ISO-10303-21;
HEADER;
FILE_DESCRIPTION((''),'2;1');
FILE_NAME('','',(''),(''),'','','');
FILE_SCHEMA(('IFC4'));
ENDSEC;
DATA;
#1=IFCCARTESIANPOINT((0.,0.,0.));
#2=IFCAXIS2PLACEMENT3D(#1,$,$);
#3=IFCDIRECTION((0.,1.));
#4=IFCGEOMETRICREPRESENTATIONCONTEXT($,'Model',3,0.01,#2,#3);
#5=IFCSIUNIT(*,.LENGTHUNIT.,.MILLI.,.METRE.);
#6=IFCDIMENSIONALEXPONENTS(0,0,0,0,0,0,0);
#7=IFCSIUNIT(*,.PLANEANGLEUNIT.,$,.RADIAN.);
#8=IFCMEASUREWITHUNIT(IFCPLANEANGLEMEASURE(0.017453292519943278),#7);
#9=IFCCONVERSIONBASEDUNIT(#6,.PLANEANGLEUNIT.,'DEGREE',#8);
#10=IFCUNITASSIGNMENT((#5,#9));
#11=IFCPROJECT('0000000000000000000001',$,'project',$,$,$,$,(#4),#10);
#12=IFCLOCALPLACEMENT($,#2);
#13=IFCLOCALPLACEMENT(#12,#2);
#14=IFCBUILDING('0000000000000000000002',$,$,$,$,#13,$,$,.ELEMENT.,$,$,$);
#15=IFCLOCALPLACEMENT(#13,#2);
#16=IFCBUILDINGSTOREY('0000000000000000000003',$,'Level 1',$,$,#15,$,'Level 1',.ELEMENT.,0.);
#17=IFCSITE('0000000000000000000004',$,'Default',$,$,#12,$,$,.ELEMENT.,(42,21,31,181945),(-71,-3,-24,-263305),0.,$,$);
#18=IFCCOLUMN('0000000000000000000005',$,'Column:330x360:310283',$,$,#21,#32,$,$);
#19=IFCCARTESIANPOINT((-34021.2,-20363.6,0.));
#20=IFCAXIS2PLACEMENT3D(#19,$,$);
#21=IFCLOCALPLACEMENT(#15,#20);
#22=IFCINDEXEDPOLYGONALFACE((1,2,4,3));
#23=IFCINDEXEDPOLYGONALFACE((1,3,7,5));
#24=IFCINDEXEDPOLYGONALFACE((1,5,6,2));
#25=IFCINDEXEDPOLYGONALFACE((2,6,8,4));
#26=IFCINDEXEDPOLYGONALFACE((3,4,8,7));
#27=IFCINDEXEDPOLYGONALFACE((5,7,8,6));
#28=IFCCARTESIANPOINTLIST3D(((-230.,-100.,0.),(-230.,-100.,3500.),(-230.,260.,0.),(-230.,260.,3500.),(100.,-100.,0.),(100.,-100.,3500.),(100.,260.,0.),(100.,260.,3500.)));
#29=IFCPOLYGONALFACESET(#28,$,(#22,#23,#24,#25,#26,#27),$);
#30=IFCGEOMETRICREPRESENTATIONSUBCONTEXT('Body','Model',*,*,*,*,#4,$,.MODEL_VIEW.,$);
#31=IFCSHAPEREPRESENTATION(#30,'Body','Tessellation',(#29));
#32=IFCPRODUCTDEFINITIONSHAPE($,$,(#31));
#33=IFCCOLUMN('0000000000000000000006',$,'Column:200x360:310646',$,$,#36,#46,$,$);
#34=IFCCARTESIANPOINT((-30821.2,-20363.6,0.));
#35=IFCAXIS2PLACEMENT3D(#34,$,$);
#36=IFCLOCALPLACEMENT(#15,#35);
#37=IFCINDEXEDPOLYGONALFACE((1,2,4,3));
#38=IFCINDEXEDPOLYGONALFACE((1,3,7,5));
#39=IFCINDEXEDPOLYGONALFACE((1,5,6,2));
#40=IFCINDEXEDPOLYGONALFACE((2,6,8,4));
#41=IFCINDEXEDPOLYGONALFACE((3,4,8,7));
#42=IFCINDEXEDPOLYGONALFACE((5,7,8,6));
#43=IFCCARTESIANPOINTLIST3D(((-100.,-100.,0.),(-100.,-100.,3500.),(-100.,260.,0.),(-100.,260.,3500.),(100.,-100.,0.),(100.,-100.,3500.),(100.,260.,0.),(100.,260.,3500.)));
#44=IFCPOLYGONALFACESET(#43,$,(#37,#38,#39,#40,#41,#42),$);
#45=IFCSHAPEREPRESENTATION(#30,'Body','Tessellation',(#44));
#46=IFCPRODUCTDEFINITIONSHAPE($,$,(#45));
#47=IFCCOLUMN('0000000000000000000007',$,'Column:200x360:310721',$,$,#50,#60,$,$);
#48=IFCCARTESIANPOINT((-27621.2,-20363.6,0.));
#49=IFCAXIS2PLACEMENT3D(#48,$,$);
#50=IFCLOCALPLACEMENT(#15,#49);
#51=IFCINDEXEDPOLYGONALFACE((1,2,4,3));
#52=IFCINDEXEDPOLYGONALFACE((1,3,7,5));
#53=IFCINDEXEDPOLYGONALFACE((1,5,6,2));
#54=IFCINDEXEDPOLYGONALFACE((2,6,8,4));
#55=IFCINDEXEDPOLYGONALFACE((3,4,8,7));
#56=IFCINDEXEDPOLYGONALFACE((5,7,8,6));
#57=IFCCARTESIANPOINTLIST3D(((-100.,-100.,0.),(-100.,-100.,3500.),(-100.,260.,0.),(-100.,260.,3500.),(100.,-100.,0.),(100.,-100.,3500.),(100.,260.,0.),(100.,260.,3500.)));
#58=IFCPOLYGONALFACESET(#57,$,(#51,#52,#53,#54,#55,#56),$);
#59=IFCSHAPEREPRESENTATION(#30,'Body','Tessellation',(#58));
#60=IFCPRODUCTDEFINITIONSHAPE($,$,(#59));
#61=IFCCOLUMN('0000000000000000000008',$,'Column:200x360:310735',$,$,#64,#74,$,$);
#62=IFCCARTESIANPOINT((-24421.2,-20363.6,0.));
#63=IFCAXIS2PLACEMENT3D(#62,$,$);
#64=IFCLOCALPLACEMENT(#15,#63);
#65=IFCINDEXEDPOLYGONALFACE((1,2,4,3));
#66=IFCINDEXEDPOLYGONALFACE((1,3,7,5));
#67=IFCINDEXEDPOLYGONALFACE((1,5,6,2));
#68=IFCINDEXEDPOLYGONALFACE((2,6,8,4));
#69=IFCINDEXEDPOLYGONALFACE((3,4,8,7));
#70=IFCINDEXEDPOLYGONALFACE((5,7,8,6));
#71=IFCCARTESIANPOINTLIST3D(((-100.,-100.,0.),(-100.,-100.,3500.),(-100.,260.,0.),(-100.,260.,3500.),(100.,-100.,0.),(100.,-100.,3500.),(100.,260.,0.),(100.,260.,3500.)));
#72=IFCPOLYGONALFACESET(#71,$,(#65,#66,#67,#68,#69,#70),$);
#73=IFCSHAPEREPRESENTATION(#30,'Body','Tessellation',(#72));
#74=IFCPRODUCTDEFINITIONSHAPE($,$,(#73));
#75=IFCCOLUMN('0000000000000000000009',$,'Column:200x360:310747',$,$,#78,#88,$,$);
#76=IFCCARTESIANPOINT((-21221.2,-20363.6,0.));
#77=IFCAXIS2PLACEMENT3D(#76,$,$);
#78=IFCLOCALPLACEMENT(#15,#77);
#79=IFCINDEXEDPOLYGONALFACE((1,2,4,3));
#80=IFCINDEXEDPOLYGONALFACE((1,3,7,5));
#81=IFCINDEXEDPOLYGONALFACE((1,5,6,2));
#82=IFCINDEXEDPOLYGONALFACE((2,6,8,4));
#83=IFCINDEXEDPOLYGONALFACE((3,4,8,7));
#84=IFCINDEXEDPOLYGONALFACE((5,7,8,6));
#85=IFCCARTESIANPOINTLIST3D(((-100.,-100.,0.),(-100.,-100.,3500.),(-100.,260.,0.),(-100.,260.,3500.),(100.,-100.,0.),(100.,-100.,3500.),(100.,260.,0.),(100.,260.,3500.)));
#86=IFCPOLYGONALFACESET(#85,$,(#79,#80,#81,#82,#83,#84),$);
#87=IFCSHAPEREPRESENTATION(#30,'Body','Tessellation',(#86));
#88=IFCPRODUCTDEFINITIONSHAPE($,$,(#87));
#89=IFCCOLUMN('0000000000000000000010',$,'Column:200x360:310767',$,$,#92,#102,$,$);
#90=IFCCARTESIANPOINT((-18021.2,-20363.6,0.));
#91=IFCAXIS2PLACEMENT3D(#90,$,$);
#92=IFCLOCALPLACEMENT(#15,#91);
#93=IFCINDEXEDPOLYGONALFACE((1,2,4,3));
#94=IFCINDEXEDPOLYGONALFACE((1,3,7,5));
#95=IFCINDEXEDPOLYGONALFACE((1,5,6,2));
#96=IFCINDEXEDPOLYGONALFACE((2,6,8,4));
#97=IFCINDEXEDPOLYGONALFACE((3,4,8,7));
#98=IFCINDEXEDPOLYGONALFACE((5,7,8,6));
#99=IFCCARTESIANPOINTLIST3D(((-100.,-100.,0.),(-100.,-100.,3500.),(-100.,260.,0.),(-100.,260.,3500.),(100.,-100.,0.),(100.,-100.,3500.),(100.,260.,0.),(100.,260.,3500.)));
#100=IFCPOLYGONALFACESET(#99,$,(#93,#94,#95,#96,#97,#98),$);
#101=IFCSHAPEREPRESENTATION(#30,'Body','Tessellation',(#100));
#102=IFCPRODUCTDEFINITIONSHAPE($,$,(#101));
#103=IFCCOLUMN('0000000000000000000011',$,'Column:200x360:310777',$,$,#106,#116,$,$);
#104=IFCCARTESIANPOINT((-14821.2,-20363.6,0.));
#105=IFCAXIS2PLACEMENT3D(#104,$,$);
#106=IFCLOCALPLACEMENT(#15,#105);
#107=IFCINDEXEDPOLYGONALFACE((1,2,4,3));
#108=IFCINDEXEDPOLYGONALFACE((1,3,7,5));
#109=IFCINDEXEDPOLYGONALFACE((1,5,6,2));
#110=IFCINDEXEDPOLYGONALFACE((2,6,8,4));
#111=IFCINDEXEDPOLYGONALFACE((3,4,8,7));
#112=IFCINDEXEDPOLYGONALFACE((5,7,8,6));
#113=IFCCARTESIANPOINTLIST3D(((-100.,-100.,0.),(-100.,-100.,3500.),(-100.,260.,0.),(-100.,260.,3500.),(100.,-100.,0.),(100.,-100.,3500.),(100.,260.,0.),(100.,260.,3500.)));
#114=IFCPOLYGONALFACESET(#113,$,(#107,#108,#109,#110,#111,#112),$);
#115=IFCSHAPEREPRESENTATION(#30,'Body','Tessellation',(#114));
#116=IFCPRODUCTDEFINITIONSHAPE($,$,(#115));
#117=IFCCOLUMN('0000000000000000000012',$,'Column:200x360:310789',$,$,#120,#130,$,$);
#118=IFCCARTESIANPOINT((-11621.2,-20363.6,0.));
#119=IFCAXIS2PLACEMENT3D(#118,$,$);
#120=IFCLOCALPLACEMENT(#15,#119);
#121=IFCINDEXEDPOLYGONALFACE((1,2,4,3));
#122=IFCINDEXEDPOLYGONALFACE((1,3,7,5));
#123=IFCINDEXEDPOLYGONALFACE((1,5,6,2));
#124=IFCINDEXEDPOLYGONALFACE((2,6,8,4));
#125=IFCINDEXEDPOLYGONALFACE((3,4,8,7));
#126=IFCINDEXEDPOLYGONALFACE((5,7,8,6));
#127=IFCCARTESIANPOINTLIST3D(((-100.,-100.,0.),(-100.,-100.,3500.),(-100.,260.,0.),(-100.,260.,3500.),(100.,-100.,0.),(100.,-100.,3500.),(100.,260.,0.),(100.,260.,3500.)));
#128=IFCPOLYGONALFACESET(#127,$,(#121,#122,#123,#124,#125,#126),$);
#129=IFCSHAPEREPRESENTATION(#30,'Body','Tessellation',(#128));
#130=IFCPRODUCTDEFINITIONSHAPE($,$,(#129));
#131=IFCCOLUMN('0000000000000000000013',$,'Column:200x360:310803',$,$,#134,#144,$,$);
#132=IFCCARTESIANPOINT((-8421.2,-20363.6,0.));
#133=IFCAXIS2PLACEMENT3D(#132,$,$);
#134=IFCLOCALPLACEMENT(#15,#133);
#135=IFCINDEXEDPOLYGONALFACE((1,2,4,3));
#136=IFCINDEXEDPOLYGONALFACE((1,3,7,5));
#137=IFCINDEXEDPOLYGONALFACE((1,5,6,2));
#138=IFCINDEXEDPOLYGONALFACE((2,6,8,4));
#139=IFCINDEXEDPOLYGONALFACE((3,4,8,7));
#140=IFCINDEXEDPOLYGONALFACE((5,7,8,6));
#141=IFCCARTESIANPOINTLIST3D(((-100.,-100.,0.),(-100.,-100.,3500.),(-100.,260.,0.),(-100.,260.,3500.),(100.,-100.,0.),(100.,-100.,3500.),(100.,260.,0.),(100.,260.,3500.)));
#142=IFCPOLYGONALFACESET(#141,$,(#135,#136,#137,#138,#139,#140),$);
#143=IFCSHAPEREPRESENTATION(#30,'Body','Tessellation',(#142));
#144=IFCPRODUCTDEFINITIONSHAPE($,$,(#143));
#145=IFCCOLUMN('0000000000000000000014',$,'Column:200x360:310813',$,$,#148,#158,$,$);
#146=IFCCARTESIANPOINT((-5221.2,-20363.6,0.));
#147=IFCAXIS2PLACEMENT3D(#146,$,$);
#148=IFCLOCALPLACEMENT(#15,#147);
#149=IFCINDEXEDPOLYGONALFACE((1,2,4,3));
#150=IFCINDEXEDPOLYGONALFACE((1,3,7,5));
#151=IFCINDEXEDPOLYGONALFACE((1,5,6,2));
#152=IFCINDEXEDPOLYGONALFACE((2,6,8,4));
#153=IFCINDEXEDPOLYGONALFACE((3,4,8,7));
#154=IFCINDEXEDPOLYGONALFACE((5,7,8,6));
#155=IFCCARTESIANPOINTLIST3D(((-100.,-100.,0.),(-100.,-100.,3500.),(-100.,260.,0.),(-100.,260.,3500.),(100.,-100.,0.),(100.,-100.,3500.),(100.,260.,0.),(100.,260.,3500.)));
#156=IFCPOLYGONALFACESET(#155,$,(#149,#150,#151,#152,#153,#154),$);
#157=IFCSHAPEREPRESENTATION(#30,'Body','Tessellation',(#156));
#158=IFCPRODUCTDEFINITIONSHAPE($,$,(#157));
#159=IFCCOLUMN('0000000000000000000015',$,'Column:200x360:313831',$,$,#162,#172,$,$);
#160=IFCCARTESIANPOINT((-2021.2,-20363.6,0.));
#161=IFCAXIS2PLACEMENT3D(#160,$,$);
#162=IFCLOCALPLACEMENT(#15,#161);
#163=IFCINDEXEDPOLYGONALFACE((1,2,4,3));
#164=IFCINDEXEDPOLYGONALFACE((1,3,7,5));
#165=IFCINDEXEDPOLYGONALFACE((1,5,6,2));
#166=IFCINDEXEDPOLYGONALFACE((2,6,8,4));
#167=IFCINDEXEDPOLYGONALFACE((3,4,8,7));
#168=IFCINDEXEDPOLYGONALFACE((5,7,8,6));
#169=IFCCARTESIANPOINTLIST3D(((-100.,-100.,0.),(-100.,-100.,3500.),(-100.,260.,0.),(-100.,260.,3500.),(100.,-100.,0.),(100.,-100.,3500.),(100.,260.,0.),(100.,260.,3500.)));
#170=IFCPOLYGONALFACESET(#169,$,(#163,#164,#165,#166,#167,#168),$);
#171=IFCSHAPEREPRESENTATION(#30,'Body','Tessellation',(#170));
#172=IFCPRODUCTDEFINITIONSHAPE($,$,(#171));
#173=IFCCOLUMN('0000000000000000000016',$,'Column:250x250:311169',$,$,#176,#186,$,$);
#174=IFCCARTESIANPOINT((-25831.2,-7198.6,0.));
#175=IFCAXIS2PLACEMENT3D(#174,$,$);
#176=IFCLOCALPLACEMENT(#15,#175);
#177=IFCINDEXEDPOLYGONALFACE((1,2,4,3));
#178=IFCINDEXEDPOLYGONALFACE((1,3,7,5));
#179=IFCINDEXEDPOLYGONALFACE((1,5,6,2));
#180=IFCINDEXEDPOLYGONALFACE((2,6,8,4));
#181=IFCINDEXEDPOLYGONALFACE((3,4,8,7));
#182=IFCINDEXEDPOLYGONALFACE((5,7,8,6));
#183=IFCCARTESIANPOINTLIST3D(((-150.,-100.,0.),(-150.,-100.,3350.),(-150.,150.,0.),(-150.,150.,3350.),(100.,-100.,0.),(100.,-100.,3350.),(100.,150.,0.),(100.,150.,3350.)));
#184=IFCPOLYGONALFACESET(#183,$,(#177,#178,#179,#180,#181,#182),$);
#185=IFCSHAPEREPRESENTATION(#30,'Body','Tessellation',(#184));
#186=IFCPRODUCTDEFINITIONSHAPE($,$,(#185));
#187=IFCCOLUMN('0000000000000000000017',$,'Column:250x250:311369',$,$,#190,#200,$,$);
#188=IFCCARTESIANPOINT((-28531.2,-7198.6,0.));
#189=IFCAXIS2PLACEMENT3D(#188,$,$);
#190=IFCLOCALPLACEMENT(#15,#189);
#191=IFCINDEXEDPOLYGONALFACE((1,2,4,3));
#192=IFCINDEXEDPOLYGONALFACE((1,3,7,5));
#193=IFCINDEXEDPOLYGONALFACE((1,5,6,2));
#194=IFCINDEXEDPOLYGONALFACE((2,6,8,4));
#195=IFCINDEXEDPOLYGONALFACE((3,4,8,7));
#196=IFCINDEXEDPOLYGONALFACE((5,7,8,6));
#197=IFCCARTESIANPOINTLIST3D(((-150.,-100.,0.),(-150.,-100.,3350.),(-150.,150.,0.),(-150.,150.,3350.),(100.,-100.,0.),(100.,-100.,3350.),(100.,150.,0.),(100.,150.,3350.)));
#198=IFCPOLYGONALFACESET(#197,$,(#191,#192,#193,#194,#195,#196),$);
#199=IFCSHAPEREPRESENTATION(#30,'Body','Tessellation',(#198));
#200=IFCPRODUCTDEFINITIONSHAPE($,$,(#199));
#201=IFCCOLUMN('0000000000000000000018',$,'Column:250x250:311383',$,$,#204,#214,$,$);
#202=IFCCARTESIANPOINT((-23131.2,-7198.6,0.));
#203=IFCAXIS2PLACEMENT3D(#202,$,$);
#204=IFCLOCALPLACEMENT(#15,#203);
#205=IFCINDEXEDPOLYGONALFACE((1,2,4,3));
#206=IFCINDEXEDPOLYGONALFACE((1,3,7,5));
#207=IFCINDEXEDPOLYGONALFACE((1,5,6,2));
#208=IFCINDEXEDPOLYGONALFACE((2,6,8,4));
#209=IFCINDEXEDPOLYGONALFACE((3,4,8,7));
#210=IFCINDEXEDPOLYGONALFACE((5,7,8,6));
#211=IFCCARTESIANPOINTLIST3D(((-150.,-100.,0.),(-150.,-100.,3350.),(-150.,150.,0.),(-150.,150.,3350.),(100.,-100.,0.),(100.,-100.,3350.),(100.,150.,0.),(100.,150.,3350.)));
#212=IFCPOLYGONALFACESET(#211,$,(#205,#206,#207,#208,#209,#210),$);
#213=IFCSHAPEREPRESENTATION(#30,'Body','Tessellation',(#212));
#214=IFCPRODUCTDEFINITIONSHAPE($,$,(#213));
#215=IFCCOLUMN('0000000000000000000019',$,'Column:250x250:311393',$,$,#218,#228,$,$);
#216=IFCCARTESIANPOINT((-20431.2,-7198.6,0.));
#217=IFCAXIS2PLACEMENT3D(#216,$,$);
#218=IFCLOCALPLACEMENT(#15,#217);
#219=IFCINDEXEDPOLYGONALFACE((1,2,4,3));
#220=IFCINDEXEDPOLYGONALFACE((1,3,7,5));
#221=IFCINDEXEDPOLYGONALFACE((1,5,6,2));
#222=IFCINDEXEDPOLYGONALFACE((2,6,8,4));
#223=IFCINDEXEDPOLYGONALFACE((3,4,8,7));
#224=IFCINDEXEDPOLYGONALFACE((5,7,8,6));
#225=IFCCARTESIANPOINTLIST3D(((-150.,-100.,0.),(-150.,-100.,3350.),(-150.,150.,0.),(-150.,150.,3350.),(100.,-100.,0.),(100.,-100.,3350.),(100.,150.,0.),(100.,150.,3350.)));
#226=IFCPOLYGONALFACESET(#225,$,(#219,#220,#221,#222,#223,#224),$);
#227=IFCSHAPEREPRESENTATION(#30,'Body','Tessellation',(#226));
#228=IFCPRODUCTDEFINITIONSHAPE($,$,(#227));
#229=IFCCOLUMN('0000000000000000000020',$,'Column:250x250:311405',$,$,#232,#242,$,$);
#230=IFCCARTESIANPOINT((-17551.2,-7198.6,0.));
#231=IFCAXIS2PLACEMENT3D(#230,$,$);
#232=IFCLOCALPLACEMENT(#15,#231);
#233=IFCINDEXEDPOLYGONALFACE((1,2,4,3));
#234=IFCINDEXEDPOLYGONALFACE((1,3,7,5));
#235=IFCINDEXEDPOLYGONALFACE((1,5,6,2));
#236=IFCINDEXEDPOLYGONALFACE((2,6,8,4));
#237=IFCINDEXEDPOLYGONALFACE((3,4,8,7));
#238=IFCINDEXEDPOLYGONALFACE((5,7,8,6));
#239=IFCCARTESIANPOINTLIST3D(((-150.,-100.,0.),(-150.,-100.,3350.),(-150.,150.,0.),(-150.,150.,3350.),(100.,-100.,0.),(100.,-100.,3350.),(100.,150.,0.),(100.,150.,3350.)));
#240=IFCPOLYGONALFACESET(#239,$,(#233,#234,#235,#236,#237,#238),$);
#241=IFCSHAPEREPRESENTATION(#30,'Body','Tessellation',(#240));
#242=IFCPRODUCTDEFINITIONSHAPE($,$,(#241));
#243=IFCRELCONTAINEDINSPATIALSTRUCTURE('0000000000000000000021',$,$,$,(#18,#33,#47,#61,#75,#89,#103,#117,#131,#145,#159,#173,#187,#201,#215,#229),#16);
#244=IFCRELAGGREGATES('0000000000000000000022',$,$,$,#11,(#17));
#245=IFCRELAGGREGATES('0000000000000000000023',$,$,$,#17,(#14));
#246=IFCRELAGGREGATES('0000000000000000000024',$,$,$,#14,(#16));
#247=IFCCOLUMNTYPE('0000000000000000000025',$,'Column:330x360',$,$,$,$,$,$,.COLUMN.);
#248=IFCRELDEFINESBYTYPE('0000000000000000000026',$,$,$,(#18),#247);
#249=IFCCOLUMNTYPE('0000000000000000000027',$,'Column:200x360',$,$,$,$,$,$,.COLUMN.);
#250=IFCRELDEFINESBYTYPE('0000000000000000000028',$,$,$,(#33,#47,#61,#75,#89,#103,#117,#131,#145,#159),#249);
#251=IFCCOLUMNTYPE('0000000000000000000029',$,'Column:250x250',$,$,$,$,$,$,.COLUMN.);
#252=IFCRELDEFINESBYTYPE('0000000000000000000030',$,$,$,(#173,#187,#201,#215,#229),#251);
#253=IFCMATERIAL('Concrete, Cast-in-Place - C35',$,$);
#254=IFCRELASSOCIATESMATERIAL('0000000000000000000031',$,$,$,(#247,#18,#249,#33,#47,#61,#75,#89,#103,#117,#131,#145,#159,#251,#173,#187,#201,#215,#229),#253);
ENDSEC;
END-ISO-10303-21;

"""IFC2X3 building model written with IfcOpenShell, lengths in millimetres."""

from ifc_helpers import new_model, entity, si_unit, converted_unit, direction, frame, frame_2d, origin, origin_2d_with_axis, place, context, subcontext, project, spatial, rectangle, extrude, source, transform, mapped, material, type_object, type_shapes, element, save


model = new_model("IFC2X3")

# Units and contexts
model_context = context("Model", 3, precision=0.01, world=origin(), true_north=direction((0.0, 1.0)))
body_context = subcontext(model_context, "Body", "Model", "MODEL_VIEW")
ifc_project = project(units=[si_unit("LENGTHUNIT", "METRE", prefix="MILLI"), converted_unit("PLANEANGLEUNIT", "DEGREE", entity("IfcPlaneAngleMeasure", 0.017453292519943278), si_unit("PLANEANGLEUNIT", "RADIAN"), dimensions=[0, 0, 0, 0, 0, 0, 0])], contexts=[model_context])

# Site, building, storey
site_placement = place(None, origin())
site = spatial("IfcSite", under=ifc_project, at=site_placement, Name="Default", CompositionType="ELEMENT", RefLatitude=(42, 21, 31, 181945), RefLongitude=(-71, -3, -24, -263305), RefElevation=0.0)
building_placement = place(site_placement, origin())
building = spatial("IfcBuilding", under=site, at=building_placement, CompositionType="ELEMENT")
storey_placement = place(building_placement, origin())
storey = spatial("IfcBuildingStorey", under=building, at=storey_placement, Name="Level 1", LongName="Level 1", CompositionType="ELEMENT", Elevation=0.0)

# Columns
ifc_material = material(Name="Concrete, Cast-in-Place - C35")
column_type_1 = type_object("IfcColumnType", Name="Column:330x360", PredefinedType="COLUMN", material=ifc_material)
shared_shape_1 = source(origin(), body_context, "Body", "SweptSolid", [
    extrude(rectangle(XDim=330.0, YDim=360.0, at=origin_2d_with_axis()), frame((-65.0, 80.0, 0.0), z_axis=(0.0, 0.0, 1.0), x_axis=(-1.0, 0.0, 0.0)), (0.0, 0.0, 1.0), 3500.0),
])
type_shapes(column_type_1, [shared_shape_1])
column_placement = place(storey_placement, frame((-34021.2, -20363.6, 0.0)))
element("IfcColumn", 1, at=column_placement, inside=storey, type_object=column_type_1, material=ifc_material, Name="Column:330x360:310283", context=body_context, shape_type="MappedRepresentation", body=[
    mapped(shared_shape_1, transform((0.0, 0.0, 0.0), scale=1.0)),
])
column_type_2 = type_object("IfcColumnType", Name="Column:200x360", PredefinedType="COLUMN", material=ifc_material)
shared_shape_2 = source(origin(), body_context, "Body", "SweptSolid", [
    extrude(rectangle(XDim=200.0, YDim=360.0, at=frame_2d((0.0, 0.0), x_axis=(1.0, 0.0))), frame((0.0, 80.0, 0.0), z_axis=(0.0, 0.0, 1.0), x_axis=(-1.0, 0.0, 0.0)), (0.0, 0.0, 1.0), 3500.0),
])
type_shapes(column_type_2, [shared_shape_2])
for number, where, name in (
    (2, (-30821.2, -20363.6, 0.0), "Column:200x360:310646"),
    (3, (-27621.2, -20363.6, 0.0), "Column:200x360:310721"),
    (4, (-24421.2, -20363.6, 0.0), "Column:200x360:310735"),
    (5, (-21221.2, -20363.6, 0.0), "Column:200x360:310747"),
    (6, (-18021.2, -20363.6, 0.0), "Column:200x360:310767"),
    (7, (-14821.2, -20363.6, 0.0), "Column:200x360:310777"),
    (8, (-11621.2, -20363.6, 0.0), "Column:200x360:310789"),
    (9, (-8421.2, -20363.6, 0.0), "Column:200x360:310803"),
    (10, (-5221.2, -20363.6, 0.0), "Column:200x360:310813"),
    (11, (-2021.2, -20363.6, 0.0), "Column:200x360:313831"),
):
    element("IfcColumn", number, at=place(storey_placement, frame(where)), inside=storey, type_object=column_type_2, material=ifc_material, Name=name, context=body_context, shape_type="MappedRepresentation", body=[
        mapped(shared_shape_2, transform((0.0, 0.0, 0.0), scale=1.0)),
    ])
column_type_3 = type_object("IfcColumnType", Name="Column:250x250", PredefinedType="COLUMN", material=ifc_material)
shared_shape_3 = source(origin(), body_context, "Body", "SweptSolid", [
    extrude(rectangle(XDim=250.0, YDim=250.0, at=origin_2d_with_axis()), frame((-25.0, 25.0, 0.0), z_axis=(0.0, 0.0, 1.0), x_axis=(-1.0, 0.0, 0.0)), (0.0, 0.0, 1.0), 3350.0),
])
type_shapes(column_type_3, [shared_shape_3])
for number, where, name in (
    (12, (-25831.2, -7198.6, 0.0), "Column:250x250:311169"),
    (13, (-28531.2, -7198.6, 0.0), "Column:250x250:311369"),
    (14, (-23131.2, -7198.6, 0.0), "Column:250x250:311383"),
    (15, (-20431.2, -7198.6, 0.0), "Column:250x250:311393"),
    (16, (-17551.2, -7198.6, 0.0), "Column:250x250:311405"),
):
    element("IfcColumn", number, at=place(storey_placement, frame(where)), inside=storey, type_object=column_type_3, material=ifc_material, Name=name, context=body_context, shape_type="MappedRepresentation", body=[
        mapped(shared_shape_3, transform((0.0, 0.0, 0.0), scale=1.0)),
    ])

save(model, "model.ifc")
